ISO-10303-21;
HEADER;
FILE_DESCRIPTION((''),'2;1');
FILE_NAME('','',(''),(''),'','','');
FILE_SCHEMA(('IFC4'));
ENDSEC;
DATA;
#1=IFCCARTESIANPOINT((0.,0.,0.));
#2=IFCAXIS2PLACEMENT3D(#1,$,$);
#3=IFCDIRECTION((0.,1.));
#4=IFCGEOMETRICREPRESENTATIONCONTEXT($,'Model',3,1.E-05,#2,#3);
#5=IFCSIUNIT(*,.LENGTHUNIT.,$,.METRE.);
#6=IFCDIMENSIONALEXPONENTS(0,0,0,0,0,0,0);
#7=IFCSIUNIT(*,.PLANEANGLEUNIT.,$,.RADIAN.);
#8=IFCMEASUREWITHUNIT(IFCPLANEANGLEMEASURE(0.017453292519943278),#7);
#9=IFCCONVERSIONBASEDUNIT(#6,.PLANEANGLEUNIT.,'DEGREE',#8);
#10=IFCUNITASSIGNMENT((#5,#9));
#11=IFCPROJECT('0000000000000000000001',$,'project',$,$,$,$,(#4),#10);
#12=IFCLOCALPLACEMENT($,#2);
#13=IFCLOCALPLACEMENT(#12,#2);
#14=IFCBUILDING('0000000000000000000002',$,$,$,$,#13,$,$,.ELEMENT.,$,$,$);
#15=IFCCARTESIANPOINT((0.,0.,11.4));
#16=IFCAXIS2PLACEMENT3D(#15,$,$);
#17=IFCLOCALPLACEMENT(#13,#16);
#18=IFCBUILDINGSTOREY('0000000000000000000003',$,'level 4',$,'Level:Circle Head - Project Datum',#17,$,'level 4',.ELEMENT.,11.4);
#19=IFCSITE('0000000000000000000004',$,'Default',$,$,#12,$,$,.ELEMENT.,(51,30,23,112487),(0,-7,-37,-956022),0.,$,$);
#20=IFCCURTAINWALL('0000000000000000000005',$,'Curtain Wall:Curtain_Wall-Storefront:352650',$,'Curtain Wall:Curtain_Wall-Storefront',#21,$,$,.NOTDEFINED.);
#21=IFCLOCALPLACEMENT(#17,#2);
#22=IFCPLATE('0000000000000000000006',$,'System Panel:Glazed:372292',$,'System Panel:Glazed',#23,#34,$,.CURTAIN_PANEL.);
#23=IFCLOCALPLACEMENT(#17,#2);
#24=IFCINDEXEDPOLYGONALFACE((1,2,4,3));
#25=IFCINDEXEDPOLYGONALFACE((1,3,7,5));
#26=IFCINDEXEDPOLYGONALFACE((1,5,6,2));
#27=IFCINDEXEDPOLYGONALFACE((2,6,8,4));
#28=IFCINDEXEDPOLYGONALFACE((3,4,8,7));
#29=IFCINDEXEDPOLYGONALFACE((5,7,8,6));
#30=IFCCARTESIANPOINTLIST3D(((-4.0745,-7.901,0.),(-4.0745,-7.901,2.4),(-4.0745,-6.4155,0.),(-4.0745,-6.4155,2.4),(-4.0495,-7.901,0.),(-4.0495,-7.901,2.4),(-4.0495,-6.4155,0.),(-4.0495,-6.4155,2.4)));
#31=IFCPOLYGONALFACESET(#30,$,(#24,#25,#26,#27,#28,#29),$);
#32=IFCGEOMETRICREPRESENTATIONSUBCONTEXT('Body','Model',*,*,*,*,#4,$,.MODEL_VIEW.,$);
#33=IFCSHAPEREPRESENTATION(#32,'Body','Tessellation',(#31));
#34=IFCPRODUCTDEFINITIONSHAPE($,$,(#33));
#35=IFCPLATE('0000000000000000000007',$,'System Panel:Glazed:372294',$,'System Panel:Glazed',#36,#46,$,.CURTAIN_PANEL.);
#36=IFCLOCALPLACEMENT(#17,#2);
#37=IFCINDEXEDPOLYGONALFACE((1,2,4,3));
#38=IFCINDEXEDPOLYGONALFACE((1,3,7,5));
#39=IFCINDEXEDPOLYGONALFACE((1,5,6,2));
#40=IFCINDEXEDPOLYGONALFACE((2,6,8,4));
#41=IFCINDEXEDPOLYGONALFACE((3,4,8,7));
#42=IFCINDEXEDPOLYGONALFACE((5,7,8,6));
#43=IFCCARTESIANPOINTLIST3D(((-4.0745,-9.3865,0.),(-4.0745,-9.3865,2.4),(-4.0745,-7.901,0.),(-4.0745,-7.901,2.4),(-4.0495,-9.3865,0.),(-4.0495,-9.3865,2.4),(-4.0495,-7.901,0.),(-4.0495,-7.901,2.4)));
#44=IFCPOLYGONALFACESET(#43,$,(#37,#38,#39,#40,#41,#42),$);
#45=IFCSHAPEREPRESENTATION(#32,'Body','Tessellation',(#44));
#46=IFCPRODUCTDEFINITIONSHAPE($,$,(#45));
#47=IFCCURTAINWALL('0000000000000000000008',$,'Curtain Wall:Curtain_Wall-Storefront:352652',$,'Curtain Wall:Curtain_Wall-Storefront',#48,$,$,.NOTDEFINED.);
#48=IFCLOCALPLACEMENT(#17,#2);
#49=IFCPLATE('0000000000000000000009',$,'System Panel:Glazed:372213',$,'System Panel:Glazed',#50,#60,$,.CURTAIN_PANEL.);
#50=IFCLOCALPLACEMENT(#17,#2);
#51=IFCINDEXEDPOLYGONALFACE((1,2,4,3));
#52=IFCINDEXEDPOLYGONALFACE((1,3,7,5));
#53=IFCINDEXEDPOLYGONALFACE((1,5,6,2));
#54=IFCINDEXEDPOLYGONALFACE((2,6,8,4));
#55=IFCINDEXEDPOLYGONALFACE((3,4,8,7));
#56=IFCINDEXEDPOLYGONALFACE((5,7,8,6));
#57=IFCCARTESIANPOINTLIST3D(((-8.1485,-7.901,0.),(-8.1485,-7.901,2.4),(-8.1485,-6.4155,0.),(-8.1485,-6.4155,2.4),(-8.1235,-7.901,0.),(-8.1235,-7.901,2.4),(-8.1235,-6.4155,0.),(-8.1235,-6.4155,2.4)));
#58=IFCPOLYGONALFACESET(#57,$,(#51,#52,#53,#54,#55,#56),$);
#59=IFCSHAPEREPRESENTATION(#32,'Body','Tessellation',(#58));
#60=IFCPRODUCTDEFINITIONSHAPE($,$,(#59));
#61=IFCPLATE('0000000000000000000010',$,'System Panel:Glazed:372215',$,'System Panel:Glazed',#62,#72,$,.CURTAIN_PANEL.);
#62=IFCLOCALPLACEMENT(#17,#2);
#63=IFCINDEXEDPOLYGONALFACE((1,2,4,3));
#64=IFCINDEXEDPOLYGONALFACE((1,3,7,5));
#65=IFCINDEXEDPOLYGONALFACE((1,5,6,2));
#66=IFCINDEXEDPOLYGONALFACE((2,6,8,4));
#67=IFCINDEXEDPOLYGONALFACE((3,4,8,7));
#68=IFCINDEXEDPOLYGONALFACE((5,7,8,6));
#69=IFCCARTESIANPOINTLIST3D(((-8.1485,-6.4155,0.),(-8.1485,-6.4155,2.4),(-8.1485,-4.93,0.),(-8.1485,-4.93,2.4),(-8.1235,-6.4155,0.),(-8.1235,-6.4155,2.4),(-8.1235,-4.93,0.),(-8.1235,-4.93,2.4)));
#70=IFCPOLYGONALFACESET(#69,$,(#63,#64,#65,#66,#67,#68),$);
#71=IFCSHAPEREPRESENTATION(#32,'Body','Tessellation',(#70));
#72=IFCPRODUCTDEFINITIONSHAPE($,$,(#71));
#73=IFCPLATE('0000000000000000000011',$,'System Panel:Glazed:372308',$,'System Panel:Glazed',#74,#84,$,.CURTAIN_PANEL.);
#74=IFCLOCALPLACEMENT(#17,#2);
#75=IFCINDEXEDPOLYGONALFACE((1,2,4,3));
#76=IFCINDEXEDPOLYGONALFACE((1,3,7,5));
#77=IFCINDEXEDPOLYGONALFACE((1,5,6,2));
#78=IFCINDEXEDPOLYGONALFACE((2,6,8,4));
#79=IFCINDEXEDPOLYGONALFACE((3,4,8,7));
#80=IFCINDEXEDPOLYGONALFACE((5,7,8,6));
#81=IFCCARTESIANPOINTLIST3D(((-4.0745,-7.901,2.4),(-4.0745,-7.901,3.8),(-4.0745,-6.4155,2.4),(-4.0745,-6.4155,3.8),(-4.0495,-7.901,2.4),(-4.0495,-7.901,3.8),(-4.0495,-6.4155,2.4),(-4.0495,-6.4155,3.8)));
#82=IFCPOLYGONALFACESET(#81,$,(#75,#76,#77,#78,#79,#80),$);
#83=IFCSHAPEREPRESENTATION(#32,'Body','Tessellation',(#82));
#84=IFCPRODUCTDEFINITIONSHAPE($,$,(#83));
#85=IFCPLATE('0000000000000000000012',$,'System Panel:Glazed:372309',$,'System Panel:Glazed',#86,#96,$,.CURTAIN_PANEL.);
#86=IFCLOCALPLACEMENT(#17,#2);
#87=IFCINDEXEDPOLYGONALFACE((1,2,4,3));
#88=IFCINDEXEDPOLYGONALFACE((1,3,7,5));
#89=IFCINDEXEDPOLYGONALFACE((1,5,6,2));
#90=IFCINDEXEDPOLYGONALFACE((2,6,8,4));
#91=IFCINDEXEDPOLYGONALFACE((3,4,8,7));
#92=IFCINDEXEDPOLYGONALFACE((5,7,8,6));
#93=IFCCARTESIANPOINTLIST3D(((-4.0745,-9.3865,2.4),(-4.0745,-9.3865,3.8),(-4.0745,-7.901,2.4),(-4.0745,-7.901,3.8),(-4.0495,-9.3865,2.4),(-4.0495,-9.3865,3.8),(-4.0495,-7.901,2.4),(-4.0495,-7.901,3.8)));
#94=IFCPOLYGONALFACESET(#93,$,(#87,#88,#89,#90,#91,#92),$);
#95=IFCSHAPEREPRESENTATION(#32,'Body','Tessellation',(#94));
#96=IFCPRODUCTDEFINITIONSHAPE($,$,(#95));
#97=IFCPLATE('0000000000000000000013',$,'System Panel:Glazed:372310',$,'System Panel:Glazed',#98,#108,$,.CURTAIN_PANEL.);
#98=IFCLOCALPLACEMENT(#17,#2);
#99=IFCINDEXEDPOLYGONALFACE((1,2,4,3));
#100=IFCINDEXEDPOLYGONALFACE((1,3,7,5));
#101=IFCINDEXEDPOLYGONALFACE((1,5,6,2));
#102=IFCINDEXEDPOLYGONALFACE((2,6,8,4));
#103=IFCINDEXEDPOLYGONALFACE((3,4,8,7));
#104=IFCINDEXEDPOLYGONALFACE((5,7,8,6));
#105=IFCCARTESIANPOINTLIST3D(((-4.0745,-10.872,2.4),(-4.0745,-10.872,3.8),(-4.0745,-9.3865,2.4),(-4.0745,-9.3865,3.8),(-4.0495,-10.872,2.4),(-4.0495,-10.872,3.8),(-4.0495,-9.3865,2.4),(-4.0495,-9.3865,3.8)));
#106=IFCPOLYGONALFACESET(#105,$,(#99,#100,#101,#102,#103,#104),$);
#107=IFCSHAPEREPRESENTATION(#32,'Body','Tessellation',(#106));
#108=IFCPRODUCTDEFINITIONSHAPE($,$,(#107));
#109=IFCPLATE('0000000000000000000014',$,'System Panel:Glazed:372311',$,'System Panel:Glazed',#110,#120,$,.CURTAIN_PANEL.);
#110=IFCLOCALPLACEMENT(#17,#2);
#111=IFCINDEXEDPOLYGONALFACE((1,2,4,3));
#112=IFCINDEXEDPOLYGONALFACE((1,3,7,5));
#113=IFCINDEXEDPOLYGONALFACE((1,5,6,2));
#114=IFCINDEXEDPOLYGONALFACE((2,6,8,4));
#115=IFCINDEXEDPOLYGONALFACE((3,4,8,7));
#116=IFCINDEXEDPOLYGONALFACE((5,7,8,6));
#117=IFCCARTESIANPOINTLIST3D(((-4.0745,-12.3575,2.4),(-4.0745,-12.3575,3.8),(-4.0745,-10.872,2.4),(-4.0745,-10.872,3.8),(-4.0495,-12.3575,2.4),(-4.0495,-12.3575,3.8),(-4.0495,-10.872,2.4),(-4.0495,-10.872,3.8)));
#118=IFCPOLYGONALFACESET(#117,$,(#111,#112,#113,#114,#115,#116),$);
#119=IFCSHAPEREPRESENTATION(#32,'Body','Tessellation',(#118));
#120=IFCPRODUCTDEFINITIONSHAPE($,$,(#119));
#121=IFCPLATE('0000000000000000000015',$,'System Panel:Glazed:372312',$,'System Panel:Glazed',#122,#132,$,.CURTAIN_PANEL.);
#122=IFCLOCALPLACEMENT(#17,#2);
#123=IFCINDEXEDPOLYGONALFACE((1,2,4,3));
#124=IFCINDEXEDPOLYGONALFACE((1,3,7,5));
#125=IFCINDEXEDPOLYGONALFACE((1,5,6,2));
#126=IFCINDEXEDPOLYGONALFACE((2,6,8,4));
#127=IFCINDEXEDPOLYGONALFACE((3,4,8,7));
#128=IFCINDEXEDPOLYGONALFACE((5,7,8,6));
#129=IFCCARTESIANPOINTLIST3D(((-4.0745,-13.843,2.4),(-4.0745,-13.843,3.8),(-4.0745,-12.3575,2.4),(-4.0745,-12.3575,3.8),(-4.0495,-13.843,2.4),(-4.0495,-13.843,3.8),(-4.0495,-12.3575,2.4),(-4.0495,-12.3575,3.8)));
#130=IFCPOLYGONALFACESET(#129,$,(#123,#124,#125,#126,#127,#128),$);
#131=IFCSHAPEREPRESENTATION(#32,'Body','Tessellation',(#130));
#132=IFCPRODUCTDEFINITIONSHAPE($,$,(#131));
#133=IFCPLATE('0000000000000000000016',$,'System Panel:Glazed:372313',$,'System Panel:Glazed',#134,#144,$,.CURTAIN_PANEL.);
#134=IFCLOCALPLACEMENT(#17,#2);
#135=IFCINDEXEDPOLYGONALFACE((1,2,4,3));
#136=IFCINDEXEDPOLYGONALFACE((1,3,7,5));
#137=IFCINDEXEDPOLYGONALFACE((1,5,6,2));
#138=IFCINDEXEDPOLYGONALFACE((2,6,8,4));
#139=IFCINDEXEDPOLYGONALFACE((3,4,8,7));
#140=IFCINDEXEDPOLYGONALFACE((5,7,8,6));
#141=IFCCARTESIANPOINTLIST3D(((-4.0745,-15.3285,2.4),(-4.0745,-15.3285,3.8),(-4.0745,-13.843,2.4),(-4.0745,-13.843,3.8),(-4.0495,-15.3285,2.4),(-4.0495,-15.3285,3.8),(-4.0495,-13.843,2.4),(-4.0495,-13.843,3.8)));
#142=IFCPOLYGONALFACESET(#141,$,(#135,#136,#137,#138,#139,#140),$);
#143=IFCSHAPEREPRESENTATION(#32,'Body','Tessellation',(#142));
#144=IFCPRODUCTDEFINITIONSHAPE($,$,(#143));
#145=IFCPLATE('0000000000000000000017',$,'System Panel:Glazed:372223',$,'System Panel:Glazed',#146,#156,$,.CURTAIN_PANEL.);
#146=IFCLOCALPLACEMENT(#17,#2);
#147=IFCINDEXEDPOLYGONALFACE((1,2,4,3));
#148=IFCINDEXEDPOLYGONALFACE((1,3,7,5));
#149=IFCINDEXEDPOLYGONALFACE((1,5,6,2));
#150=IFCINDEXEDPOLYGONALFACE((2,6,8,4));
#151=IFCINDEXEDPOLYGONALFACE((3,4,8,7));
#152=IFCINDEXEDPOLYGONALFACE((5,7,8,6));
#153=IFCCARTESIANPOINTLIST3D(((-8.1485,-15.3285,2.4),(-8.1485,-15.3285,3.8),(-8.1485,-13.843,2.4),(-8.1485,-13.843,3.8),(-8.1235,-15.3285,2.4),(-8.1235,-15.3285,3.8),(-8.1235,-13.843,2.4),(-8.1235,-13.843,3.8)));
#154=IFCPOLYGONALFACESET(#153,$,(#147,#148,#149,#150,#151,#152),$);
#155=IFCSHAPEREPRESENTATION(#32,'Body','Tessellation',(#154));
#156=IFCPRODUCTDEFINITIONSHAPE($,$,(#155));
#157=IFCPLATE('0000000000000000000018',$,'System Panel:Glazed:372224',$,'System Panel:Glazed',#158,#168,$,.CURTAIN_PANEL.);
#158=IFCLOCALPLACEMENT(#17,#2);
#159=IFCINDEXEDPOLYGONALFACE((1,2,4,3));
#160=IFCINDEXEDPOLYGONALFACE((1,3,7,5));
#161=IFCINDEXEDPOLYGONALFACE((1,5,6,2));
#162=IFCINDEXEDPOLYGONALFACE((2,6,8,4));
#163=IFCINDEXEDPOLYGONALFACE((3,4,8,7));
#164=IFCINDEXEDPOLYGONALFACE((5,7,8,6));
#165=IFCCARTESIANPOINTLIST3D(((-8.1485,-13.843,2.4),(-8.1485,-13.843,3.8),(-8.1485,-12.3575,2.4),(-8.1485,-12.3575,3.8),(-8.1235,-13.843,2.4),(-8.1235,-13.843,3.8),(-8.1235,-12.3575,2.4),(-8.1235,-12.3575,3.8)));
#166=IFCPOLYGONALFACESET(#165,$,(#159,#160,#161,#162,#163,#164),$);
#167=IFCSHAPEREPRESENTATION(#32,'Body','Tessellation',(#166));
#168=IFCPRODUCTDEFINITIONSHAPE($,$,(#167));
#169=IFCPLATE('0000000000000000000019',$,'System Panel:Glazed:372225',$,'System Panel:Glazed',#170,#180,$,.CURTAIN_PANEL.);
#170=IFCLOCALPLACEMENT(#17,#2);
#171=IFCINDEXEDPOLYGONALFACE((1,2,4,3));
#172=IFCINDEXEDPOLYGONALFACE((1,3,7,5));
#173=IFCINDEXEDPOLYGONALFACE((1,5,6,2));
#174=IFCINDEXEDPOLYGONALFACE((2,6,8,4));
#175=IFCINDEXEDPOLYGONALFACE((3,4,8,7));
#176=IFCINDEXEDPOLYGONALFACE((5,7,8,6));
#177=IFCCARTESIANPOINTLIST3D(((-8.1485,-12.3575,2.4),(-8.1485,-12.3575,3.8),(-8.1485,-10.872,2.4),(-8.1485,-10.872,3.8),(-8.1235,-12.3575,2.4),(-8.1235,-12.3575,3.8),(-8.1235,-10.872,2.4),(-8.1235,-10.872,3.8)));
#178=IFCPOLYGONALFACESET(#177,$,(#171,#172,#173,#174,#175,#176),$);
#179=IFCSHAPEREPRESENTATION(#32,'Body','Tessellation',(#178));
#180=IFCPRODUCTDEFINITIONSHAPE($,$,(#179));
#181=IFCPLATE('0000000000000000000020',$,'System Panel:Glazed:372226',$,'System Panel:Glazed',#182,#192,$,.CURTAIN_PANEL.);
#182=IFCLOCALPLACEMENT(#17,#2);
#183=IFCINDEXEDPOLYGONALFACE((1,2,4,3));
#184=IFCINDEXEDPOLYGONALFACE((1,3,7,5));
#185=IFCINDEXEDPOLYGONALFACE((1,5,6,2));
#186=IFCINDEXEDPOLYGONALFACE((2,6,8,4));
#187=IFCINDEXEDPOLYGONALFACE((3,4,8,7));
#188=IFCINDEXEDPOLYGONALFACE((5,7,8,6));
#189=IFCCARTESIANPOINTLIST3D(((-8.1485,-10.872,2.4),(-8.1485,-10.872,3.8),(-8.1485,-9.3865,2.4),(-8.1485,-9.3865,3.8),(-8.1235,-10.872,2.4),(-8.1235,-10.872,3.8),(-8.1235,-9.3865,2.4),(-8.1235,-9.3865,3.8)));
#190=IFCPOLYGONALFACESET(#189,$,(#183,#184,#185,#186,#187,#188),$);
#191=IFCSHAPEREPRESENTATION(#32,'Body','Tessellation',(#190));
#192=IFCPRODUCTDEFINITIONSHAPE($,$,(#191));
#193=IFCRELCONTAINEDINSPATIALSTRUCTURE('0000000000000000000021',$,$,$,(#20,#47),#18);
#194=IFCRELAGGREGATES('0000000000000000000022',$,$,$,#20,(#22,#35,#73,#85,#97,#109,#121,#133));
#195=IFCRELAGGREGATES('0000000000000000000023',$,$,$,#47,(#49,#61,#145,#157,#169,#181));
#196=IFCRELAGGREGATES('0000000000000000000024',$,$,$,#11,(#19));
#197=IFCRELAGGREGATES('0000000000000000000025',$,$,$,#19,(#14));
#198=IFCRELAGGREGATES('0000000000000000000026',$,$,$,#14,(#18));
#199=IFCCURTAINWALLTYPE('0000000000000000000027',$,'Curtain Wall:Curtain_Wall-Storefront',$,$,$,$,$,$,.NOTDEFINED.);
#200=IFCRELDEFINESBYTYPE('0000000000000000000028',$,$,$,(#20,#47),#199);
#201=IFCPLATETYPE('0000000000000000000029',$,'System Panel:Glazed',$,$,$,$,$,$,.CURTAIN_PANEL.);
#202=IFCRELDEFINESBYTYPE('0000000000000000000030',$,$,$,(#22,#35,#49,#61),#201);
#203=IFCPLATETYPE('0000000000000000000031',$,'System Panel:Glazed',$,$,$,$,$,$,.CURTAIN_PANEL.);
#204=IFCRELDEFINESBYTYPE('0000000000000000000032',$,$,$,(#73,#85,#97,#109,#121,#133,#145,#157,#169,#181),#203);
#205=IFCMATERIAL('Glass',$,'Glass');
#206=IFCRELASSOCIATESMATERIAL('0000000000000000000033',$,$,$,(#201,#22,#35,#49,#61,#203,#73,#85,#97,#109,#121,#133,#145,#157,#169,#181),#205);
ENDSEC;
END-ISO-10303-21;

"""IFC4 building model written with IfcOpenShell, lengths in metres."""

from ifc_helpers import new_model, entity, si_unit, converted_unit, direction, frame, origin, origin_2d_with_axis, place, context, subcontext, project, spatial, rectangle, extrude, source, transform, mapped, material, type_object, type_shapes, element, aggregate, save


model = new_model("IFC4")

# Units and contexts
model_context = context("Model", 3, precision=1e-05, world=origin(), true_north=direction((0.0, 1.0)))
body_context = subcontext(model_context, "Body", "Model", "MODEL_VIEW")
ifc_project = project(units=[si_unit("LENGTHUNIT", "METRE"), converted_unit("PLANEANGLEUNIT", "DEGREE", entity("IfcPlaneAngleMeasure", 0.017453292519943278), si_unit("PLANEANGLEUNIT", "RADIAN"), dimensions=[0, 0, 0, 0, 0, 0, 0])], contexts=[model_context])

# Site, building, storey
site_placement = place(None, origin())
site = spatial("IfcSite", under=ifc_project, at=site_placement, Name="Default", CompositionType="ELEMENT", RefLatitude=(51, 30, 23, 112487), RefLongitude=(0, -7, -37, -956022), RefElevation=0.0)
building_placement = place(site_placement, origin())
building = spatial("IfcBuilding", under=site, at=building_placement, CompositionType="ELEMENT")
storey_placement = place(building_placement, frame((0.0, 0.0, 11.4)))
storey = spatial("IfcBuildingStorey", under=building, at=storey_placement, Name="level 4", ObjectType="Level:Circle Head - Project Datum", LongName="level 4", CompositionType="ELEMENT", Elevation=11.4)

# Curtain walls, plates
curtain_wall_type = type_object("IfcCurtainWallType", Name="Curtain Wall:Curtain_Wall-Storefront", PredefinedType="NOTDEFINED")
curtain_wall_1_placement = place(storey_placement, frame((0.0, 0.0, -11.4)))
curtain_wall_1 = element("IfcCurtainWall", 1, at=curtain_wall_1_placement, inside=storey, type_object=curtain_wall_type, Name="Curtain Wall:Curtain_Wall-Storefront:352650", ObjectType="Curtain Wall:Curtain_Wall-Storefront", PredefinedType="NOTDEFINED")
ifc_material = material(Name="Glass", Category="Glass")
plate_type_1 = type_object("IfcPlateType", Name="System Panel:Glazed", PredefinedType="CURTAIN_PANEL", material=ifc_material)
shared_shape_1 = source(origin(), body_context, "Body", "SweptSolid", [
    extrude(rectangle(XDim=0.025, YDim=1.4855, at=origin_2d_with_axis()), frame((0.7428, 0.0125, 0.0), z_axis=(0.0, 0.0, 1.0), x_axis=(0.0, 1.0, 0.0)), (0.0, 0.0, 1.0), 2.4),
])
type_shapes(plate_type_1, [shared_shape_1])
plate_1_placement = place(curtain_wall_1_placement, frame((-4.0745, -6.4155, 11.4), z_axis=(0.0, 0.0, 1.0), x_axis=(0.0, -1.0, 0.0)))
plate_1 = element("IfcPlate", 2, at=plate_1_placement, type_object=plate_type_1, material=ifc_material, Name="System Panel:Glazed:372292", ObjectType="System Panel:Glazed", PredefinedType="CURTAIN_PANEL", context=body_context, shape_type="MappedRepresentation", body=[
    mapped(shared_shape_1, transform((0.0, 0.0, 0.0), scale=1.0)),
])
plate_2_placement = place(curtain_wall_1_placement, frame((-4.0745, -7.901, 11.4), z_axis=(0.0, 0.0, 1.0), x_axis=(0.0, -1.0, 0.0)))
plate_2 = element("IfcPlate", 3, at=plate_2_placement, type_object=plate_type_1, material=ifc_material, Name="System Panel:Glazed:372294", ObjectType="System Panel:Glazed", PredefinedType="CURTAIN_PANEL", context=body_context, shape_type="MappedRepresentation", body=[
    mapped(shared_shape_1, transform((0.0, 0.0, 0.0), scale=1.0)),
])
curtain_wall_2_placement = place(storey_placement, frame((0.0, 0.0, -11.4)))
curtain_wall_2 = element("IfcCurtainWall", 4, at=curtain_wall_2_placement, inside=storey, type_object=curtain_wall_type, Name="Curtain Wall:Curtain_Wall-Storefront:352652", ObjectType="Curtain Wall:Curtain_Wall-Storefront", PredefinedType="NOTDEFINED")
plate_3_placement = place(curtain_wall_2_placement, frame((-8.1235, -7.901, 11.4), z_axis=(0.0, 0.0, 1.0), x_axis=(0.0, 1.0, 0.0)))
plate_3 = element("IfcPlate", 5, at=plate_3_placement, type_object=plate_type_1, material=ifc_material, Name="System Panel:Glazed:372213", ObjectType="System Panel:Glazed", PredefinedType="CURTAIN_PANEL", context=body_context, shape_type="MappedRepresentation", body=[
    mapped(shared_shape_1, transform((0.0, 0.0, 0.0), scale=1.0)),
])
plate_4_placement = place(curtain_wall_2_placement, frame((-8.1235, -6.4155, 11.4), z_axis=(0.0, 0.0, 1.0), x_axis=(0.0, 1.0, 0.0)))
plate_4 = element("IfcPlate", 6, at=plate_4_placement, type_object=plate_type_1, material=ifc_material, Name="System Panel:Glazed:372215", ObjectType="System Panel:Glazed", PredefinedType="CURTAIN_PANEL", context=body_context, shape_type="MappedRepresentation", body=[
    mapped(shared_shape_1, transform((0.0, 0.0, 0.0), scale=1.0)),
])

# Plates
plate_type_2 = type_object("IfcPlateType", Name="System Panel:Glazed", PredefinedType="CURTAIN_PANEL", material=ifc_material)
shared_shape_2 = source(origin(), body_context, "Body", "SweptSolid", [
    extrude(rectangle(XDim=0.025, YDim=1.4855, at=origin_2d_with_axis()), frame((0.7428, 0.0125, 0.0), z_axis=(0.0, 0.0, 1.0), x_axis=(0.0, 1.0, 0.0)), (0.0, 0.0, 1.0), 1.4),
])
type_shapes(plate_type_2, [shared_shape_2])
plate_5_placement = place(curtain_wall_1_placement, frame((-4.0745, -6.4155, 13.8), z_axis=(0.0, 0.0, 1.0), x_axis=(0.0, -1.0, 0.0)))
plate_5 = element("IfcPlate", 7, at=plate_5_placement, type_object=plate_type_2, material=ifc_material, Name="System Panel:Glazed:372308", ObjectType="System Panel:Glazed", PredefinedType="CURTAIN_PANEL", context=body_context, shape_type="MappedRepresentation", body=[
    mapped(shared_shape_2, transform((0.0, 0.0, 0.0), scale=1.0)),
])
plate_6_placement = place(curtain_wall_1_placement, frame((-4.0745, -7.901, 13.8), z_axis=(0.0, 0.0, 1.0), x_axis=(0.0, -1.0, 0.0)))
plate_6 = element("IfcPlate", 8, at=plate_6_placement, type_object=plate_type_2, material=ifc_material, Name="System Panel:Glazed:372309", ObjectType="System Panel:Glazed", PredefinedType="CURTAIN_PANEL", context=body_context, shape_type="MappedRepresentation", body=[
    mapped(shared_shape_2, transform((0.0, 0.0, 0.0), scale=1.0)),
])
plate_7_placement = place(curtain_wall_1_placement, frame((-4.0745, -9.3865, 13.8), z_axis=(0.0, 0.0, 1.0), x_axis=(0.0, -1.0, 0.0)))
plate_7 = element("IfcPlate", 9, at=plate_7_placement, type_object=plate_type_2, material=ifc_material, Name="System Panel:Glazed:372310", ObjectType="System Panel:Glazed", PredefinedType="CURTAIN_PANEL", context=body_context, shape_type="MappedRepresentation", body=[
    mapped(shared_shape_2, transform((0.0, 0.0, 0.0), scale=1.0)),
])
plate_8_placement = place(curtain_wall_1_placement, frame((-4.0745, -10.872, 13.8), z_axis=(0.0, 0.0, 1.0), x_axis=(0.0, -1.0, 0.0)))
plate_8 = element("IfcPlate", 10, at=plate_8_placement, type_object=plate_type_2, material=ifc_material, Name="System Panel:Glazed:372311", ObjectType="System Panel:Glazed", PredefinedType="CURTAIN_PANEL", context=body_context, shape_type="MappedRepresentation", body=[
    mapped(shared_shape_2, transform((0.0, 0.0, 0.0), scale=1.0)),
])
plate_9_placement = place(curtain_wall_1_placement, frame((-4.0745, -12.3575, 13.8), z_axis=(0.0, 0.0, 1.0), x_axis=(0.0, -1.0, 0.0)))
plate_9 = element("IfcPlate", 11, at=plate_9_placement, type_object=plate_type_2, material=ifc_material, Name="System Panel:Glazed:372312", ObjectType="System Panel:Glazed", PredefinedType="CURTAIN_PANEL", context=body_context, shape_type="MappedRepresentation", body=[
    mapped(shared_shape_2, transform((0.0, 0.0, 0.0), scale=1.0)),
])
plate_10_placement = place(curtain_wall_1_placement, frame((-4.0745, -13.843, 13.8), z_axis=(0.0, 0.0, 1.0), x_axis=(0.0, -1.0, 0.0)))
plate_10 = element("IfcPlate", 12, at=plate_10_placement, type_object=plate_type_2, material=ifc_material, Name="System Panel:Glazed:372313", ObjectType="System Panel:Glazed", PredefinedType="CURTAIN_PANEL", context=body_context, shape_type="MappedRepresentation", body=[
    mapped(shared_shape_2, transform((0.0, 0.0, 0.0), scale=1.0)),
])
aggregate(curtain_wall_1, [plate_1, plate_2, plate_5, plate_6, plate_7, plate_8, plate_9, plate_10])
plate_11_placement = place(curtain_wall_2_placement, frame((-8.1235, -15.3285, 13.8), z_axis=(0.0, 0.0, 1.0), x_axis=(0.0, 1.0, 0.0)))
plate_11 = element("IfcPlate", 13, at=plate_11_placement, type_object=plate_type_2, material=ifc_material, Name="System Panel:Glazed:372223", ObjectType="System Panel:Glazed", PredefinedType="CURTAIN_PANEL", context=body_context, shape_type="MappedRepresentation", body=[
    mapped(shared_shape_2, transform((0.0, 0.0, 0.0), scale=1.0)),
])
plate_12_placement = place(curtain_wall_2_placement, frame((-8.1235, -13.843, 13.8), z_axis=(0.0, 0.0, 1.0), x_axis=(0.0, 1.0, 0.0)))
plate_12 = element("IfcPlate", 14, at=plate_12_placement, type_object=plate_type_2, material=ifc_material, Name="System Panel:Glazed:372224", ObjectType="System Panel:Glazed", PredefinedType="CURTAIN_PANEL", context=body_context, shape_type="MappedRepresentation", body=[
    mapped(shared_shape_2, transform((0.0, 0.0, 0.0), scale=1.0)),
])
plate_13_placement = place(curtain_wall_2_placement, frame((-8.1235, -12.3575, 13.8), z_axis=(0.0, 0.0, 1.0), x_axis=(0.0, 1.0, 0.0)))
plate_13 = element("IfcPlate", 15, at=plate_13_placement, type_object=plate_type_2, material=ifc_material, Name="System Panel:Glazed:372225", ObjectType="System Panel:Glazed", PredefinedType="CURTAIN_PANEL", context=body_context, shape_type="MappedRepresentation", body=[
    mapped(shared_shape_2, transform((0.0, 0.0, 0.0), scale=1.0)),
])
plate_14_placement = place(curtain_wall_2_placement, frame((-8.1235, -10.872, 13.8), z_axis=(0.0, 0.0, 1.0), x_axis=(0.0, 1.0, 0.0)))
plate_14 = element("IfcPlate", 16, at=plate_14_placement, type_object=plate_type_2, material=ifc_material, Name="System Panel:Glazed:372226", ObjectType="System Panel:Glazed", PredefinedType="CURTAIN_PANEL", context=body_context, shape_type="MappedRepresentation", body=[
    mapped(shared_shape_2, transform((0.0, 0.0, 0.0), scale=1.0)),
])
aggregate(curtain_wall_2, [plate_3, plate_4, plate_11, plate_12, plate_13, plate_14])

save(model, "model.ifc")
